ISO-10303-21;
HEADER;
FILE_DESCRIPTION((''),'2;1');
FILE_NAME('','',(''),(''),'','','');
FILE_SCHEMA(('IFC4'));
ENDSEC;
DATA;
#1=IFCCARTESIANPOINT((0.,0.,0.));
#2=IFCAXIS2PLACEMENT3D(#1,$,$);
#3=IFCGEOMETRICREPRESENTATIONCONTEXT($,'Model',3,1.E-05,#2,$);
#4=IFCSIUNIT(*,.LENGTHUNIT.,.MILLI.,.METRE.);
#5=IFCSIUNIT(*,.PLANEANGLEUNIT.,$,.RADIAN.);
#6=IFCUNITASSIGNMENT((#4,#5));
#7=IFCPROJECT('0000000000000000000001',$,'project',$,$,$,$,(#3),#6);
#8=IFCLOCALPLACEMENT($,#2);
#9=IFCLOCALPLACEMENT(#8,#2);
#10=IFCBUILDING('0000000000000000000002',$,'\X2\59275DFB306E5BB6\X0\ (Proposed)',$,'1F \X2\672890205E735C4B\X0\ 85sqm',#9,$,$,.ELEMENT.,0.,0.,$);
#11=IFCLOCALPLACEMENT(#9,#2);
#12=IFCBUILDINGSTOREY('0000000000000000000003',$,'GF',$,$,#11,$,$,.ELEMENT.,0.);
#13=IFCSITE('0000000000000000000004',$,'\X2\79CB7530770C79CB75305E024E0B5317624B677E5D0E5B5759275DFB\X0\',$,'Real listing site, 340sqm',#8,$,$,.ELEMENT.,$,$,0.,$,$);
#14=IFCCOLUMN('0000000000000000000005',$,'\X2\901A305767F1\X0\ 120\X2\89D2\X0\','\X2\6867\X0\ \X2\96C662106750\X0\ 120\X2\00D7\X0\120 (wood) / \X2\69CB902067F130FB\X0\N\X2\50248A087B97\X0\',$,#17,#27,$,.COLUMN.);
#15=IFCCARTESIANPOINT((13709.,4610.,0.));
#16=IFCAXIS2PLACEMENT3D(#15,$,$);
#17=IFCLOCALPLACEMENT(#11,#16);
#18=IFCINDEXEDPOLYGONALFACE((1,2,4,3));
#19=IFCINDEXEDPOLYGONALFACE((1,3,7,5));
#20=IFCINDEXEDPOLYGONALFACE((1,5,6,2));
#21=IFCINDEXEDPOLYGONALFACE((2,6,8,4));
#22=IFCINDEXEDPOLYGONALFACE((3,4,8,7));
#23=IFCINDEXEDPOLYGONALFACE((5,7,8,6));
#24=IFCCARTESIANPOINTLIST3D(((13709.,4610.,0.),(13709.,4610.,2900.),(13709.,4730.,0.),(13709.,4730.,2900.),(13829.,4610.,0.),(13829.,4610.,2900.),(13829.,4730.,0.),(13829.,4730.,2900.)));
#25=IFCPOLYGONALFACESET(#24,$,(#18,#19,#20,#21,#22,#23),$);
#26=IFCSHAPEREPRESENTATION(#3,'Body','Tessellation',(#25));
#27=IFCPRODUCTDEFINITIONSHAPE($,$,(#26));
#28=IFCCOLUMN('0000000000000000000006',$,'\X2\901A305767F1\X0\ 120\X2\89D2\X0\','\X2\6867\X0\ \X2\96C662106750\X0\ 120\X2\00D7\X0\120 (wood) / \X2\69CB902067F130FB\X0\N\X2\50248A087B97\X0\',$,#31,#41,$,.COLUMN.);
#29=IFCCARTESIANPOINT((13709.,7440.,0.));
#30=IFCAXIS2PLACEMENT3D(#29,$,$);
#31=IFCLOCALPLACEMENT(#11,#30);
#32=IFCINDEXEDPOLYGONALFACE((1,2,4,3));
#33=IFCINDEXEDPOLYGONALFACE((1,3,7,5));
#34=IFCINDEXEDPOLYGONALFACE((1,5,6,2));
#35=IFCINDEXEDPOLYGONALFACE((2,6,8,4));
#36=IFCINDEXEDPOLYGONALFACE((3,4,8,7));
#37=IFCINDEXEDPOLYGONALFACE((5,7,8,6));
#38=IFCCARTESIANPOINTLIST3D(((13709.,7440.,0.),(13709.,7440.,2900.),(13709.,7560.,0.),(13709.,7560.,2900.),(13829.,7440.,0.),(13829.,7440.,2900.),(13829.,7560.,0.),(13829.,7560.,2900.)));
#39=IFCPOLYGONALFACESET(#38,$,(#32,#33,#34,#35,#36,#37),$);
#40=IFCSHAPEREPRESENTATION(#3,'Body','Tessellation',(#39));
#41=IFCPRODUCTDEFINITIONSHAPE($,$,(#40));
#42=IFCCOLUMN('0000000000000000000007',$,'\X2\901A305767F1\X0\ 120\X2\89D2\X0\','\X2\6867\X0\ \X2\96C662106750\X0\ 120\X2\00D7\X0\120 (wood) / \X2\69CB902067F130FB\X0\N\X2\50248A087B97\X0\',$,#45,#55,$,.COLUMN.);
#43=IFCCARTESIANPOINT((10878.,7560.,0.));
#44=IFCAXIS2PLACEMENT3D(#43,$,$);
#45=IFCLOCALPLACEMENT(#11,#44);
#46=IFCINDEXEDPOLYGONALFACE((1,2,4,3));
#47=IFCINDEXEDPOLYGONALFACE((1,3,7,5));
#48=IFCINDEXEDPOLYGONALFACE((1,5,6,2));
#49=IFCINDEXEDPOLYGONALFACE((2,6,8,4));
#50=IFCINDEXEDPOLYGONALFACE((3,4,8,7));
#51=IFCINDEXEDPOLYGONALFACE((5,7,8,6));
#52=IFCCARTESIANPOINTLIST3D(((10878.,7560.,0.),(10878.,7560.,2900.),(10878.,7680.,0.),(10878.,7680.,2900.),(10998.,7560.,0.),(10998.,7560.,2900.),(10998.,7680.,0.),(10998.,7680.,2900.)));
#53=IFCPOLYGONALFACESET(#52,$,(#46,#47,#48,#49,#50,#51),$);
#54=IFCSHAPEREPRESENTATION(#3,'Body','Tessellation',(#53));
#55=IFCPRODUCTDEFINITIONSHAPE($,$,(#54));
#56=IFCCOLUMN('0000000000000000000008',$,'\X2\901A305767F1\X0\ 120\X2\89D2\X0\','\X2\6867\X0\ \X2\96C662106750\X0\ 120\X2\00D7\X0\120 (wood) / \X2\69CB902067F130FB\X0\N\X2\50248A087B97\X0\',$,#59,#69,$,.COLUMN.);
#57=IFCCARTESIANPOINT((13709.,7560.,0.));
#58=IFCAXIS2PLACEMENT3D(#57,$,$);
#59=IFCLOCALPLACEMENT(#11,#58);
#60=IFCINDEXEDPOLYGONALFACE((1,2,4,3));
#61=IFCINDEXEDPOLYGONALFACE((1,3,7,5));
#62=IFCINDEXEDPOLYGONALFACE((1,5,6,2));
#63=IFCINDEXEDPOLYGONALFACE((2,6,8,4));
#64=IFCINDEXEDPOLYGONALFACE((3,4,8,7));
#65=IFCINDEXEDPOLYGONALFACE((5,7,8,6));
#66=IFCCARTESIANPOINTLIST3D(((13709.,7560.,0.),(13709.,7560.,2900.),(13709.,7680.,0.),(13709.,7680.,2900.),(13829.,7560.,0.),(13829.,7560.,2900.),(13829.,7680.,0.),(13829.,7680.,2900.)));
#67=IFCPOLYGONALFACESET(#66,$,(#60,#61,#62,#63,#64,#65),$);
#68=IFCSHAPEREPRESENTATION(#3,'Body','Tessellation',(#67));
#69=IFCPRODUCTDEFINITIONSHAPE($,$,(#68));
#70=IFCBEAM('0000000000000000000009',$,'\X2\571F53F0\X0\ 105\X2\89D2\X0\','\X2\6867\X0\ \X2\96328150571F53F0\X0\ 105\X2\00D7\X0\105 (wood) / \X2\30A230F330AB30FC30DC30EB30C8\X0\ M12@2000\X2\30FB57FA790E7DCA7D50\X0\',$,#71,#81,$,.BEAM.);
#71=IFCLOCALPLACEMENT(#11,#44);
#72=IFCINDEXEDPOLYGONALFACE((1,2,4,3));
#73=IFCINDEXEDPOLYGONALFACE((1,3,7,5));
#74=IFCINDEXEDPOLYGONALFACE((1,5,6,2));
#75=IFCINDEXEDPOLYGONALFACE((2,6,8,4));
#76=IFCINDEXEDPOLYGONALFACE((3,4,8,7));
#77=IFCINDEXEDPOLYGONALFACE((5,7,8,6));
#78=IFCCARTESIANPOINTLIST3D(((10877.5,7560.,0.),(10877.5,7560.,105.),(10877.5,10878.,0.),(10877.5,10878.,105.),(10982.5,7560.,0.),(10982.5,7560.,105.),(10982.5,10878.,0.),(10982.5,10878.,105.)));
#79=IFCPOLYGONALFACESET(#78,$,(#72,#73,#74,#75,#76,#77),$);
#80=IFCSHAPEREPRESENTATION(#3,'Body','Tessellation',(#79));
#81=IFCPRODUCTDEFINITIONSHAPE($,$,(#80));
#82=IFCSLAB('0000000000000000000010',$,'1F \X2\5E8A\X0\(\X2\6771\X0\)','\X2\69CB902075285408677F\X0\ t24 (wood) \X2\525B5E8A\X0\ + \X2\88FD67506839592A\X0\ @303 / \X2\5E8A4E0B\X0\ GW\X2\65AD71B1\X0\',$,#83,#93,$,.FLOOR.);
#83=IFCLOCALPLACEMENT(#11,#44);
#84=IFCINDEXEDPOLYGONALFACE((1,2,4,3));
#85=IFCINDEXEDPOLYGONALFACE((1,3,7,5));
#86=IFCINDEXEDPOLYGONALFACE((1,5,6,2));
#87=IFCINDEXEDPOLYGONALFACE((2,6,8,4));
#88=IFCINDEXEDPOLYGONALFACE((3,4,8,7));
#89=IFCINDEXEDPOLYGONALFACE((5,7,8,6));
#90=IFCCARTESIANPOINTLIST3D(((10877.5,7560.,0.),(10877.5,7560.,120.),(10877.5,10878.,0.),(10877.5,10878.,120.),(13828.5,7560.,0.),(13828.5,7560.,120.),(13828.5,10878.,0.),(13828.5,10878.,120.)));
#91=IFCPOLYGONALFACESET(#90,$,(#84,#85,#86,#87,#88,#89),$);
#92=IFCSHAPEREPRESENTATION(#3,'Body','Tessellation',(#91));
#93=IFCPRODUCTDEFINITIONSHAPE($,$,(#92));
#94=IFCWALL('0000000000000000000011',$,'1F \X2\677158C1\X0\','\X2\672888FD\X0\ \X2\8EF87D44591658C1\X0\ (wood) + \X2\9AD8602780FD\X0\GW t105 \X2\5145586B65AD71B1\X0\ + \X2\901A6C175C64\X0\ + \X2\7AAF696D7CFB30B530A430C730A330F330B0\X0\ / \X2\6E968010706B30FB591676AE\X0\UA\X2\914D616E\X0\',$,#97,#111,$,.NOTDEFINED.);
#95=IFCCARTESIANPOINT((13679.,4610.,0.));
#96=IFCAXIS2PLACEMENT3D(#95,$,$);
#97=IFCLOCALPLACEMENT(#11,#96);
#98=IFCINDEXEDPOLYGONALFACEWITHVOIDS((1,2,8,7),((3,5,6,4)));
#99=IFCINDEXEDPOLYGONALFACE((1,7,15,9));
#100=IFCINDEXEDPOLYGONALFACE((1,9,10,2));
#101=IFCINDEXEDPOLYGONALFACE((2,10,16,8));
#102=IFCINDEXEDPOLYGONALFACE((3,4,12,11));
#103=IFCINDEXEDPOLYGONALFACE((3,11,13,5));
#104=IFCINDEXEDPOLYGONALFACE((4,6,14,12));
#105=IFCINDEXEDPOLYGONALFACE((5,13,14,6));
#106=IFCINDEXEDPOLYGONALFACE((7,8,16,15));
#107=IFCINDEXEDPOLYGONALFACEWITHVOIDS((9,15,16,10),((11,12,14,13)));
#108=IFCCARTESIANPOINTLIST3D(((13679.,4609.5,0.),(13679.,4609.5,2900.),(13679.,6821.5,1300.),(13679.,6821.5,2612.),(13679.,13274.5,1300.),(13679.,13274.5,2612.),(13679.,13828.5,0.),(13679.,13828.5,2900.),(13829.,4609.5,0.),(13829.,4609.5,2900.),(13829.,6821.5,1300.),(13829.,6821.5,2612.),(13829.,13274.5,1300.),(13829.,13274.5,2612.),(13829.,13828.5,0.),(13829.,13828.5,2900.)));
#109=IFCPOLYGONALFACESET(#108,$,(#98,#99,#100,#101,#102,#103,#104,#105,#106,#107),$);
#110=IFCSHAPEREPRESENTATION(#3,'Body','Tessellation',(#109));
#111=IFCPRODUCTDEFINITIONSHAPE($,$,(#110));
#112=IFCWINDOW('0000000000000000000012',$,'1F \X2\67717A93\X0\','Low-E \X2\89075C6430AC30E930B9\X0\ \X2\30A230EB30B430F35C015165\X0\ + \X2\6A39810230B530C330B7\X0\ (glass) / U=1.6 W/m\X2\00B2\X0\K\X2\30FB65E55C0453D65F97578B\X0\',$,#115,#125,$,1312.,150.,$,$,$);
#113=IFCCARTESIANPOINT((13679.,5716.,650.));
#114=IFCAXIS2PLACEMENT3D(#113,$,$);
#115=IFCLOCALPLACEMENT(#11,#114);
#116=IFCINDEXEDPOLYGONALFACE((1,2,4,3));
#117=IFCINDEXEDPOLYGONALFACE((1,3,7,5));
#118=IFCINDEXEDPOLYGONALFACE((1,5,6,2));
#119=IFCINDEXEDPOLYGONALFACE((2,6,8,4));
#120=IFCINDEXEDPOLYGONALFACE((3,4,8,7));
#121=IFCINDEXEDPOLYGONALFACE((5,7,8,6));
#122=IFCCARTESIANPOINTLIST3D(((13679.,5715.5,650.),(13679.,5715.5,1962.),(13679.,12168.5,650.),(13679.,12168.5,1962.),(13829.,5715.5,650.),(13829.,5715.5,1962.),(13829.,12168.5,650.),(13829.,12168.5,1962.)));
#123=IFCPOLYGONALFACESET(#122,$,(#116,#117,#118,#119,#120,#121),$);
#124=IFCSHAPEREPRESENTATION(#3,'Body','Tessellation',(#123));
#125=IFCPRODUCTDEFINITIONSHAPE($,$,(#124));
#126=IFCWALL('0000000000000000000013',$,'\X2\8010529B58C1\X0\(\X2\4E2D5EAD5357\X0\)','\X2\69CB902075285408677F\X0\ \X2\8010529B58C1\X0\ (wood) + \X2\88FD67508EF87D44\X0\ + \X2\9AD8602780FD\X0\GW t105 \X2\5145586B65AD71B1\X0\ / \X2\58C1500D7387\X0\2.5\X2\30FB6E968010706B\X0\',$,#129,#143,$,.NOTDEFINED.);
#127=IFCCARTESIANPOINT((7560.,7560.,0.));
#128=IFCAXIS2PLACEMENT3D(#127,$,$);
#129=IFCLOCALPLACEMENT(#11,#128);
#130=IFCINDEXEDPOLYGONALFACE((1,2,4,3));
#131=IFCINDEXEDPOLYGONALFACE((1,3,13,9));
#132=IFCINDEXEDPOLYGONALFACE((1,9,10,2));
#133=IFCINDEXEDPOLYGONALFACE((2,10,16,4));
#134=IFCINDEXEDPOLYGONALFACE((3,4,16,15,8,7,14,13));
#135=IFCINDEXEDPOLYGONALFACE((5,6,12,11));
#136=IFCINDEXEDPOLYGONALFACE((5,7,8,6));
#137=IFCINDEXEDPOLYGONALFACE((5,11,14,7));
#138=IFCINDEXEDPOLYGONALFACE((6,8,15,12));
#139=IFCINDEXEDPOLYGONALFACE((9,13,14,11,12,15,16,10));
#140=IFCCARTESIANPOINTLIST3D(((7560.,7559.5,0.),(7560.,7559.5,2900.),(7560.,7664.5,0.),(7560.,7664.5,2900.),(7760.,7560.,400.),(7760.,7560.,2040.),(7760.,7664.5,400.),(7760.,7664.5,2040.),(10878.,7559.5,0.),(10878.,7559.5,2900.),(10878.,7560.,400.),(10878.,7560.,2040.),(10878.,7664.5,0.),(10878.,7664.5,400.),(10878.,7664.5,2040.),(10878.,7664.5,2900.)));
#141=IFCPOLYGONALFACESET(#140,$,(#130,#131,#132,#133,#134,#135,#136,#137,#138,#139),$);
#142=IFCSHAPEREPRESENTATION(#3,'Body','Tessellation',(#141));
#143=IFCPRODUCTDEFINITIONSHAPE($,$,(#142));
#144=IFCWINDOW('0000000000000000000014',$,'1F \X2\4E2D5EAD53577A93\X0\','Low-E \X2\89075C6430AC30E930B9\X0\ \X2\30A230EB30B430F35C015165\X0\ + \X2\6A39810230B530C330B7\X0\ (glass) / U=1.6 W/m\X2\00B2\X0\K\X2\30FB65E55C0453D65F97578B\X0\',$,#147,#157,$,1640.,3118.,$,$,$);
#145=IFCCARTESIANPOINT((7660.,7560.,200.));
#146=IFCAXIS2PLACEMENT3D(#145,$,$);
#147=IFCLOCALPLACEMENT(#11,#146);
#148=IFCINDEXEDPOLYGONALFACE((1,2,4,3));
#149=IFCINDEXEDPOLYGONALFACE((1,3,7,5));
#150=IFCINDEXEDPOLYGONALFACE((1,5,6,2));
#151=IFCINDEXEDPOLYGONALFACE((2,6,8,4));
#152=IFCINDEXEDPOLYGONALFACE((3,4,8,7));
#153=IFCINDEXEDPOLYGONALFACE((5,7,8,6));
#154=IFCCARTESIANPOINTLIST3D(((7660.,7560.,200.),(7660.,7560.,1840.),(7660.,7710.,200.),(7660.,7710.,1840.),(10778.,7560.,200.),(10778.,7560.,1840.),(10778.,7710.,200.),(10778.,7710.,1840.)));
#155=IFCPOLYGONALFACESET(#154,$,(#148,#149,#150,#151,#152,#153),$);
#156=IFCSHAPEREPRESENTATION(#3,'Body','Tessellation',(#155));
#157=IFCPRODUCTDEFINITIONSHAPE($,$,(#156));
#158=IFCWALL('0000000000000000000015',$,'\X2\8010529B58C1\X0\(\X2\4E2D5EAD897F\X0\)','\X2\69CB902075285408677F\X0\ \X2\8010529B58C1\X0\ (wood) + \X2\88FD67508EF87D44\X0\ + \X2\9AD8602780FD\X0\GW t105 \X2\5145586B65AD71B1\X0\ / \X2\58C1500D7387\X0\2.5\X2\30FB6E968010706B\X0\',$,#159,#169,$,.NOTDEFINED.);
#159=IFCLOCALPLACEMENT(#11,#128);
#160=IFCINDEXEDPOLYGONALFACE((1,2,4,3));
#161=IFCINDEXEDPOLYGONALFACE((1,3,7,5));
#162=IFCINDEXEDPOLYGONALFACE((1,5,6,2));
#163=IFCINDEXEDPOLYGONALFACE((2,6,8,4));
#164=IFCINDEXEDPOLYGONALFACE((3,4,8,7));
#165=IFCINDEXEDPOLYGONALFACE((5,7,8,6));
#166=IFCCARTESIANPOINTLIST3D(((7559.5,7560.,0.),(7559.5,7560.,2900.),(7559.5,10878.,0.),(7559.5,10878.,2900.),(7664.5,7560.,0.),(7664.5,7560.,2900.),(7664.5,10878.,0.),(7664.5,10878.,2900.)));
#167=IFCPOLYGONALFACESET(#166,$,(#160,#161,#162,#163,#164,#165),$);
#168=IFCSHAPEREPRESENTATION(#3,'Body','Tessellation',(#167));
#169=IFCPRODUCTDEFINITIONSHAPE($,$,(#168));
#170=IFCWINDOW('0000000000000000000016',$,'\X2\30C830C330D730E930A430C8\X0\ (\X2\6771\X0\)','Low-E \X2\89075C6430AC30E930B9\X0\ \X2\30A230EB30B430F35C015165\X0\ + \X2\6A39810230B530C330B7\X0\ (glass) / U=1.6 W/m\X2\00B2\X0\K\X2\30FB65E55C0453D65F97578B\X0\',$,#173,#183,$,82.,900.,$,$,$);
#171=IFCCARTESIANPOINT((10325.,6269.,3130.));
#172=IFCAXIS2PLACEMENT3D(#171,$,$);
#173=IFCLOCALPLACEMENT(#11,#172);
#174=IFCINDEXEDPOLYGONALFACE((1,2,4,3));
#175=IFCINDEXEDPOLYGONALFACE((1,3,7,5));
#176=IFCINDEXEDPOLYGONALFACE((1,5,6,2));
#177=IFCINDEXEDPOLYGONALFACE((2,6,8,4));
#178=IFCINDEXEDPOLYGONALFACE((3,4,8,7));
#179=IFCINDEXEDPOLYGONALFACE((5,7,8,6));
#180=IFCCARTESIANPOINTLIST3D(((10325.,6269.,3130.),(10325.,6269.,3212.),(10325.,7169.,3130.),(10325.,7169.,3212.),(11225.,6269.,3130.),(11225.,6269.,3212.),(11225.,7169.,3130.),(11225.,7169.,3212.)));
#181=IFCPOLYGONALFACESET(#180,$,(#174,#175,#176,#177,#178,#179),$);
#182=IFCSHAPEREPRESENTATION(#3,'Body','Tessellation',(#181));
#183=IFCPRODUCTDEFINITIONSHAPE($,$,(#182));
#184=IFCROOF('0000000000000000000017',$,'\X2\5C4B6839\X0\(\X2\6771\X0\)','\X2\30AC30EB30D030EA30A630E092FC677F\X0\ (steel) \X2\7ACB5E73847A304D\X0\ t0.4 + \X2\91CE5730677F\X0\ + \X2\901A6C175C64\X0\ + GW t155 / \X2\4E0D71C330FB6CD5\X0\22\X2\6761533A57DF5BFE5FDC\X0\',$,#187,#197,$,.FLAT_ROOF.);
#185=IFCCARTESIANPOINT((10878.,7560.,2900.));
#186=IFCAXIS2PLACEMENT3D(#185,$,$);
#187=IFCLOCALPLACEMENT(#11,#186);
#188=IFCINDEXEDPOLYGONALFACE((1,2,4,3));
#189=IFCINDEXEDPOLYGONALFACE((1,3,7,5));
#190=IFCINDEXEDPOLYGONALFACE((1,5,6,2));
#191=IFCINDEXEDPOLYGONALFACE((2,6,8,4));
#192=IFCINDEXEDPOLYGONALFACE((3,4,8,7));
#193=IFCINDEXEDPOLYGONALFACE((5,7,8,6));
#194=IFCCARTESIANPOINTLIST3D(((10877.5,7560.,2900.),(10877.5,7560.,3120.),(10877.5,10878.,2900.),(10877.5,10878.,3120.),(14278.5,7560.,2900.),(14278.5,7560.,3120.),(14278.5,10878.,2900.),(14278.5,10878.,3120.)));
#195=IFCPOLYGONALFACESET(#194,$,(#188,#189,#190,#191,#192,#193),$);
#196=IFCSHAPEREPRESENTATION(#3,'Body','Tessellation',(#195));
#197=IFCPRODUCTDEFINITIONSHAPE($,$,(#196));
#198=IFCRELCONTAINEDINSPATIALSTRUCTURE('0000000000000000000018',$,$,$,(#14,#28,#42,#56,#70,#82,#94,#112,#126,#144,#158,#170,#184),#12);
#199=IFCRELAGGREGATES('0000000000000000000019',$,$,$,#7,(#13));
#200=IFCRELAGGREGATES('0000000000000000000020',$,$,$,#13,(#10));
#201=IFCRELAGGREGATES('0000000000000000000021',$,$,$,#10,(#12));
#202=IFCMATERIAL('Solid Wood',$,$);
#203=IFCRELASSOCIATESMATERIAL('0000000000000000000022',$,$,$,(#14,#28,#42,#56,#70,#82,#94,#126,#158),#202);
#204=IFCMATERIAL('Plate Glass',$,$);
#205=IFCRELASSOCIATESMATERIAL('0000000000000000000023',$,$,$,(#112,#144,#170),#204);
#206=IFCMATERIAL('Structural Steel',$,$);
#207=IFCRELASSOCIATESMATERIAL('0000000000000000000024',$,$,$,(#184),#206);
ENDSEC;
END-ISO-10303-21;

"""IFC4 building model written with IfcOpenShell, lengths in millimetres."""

from ifc_helpers import new_model, si_unit, frame, frame_2d, origin, place, context, project, spatial, rectangle, extrude, material, element, fill, save


model = new_model("IFC4")

# Units and contexts
model_context = context("Model", 3, precision=1e-05, world=origin())
ifc_project = project(units=[si_unit("LENGTHUNIT", "METRE", prefix="MILLI"), si_unit("PLANEANGLEUNIT", "RADIAN")], contexts=[model_context])

# Site, building, storey
site_placement = place(None, origin())
site = spatial("IfcSite", under=ifc_project, at=site_placement, Name="秋田県秋田市下北手松崎字大巻", ObjectType="Real listing site, 340sqm", CompositionType="ELEMENT", RefElevation=0.0)
building_placement = place(site_placement, origin())
building = spatial("IfcBuilding", under=site, at=building_placement, Name="大巻の家 (Proposed)", ObjectType="1F 木造平屋 85sqm", CompositionType="ELEMENT", ElevationOfRefHeight=0.0, ElevationOfTerrain=0.0)
storey_placement = place(building_placement, origin())
storey = spatial("IfcBuildingStorey", under=building, at=storey_placement, Name="GF", CompositionType="ELEMENT", Elevation=0.0)

# Columns
ifc_material_1 = material(Name="Solid Wood")
column_1_placement = place(storey_placement, frame((13709.0, 4610.0, 0.0)))
element("IfcColumn", 1, at=column_1_placement, inside=storey, material=ifc_material_1, Name="通し柱 120角", Description="桧 集成材 120×120 (wood) / 構造柱・N値計算", PredefinedType="COLUMN", context=model_context, shape_type="SweptSolid", body=[
    extrude(rectangle(XDim=120.0, YDim=120.0, at=frame_2d((60.0, 60.0))), frame((13709.0, 4610.0, 0.0)), (0.0, 0.0, 1.0), 2900.0),
])
column_2_placement = place(storey_placement, frame((13709.0, 7440.0, 0.0)))
element("IfcColumn", 2, at=column_2_placement, inside=storey, material=ifc_material_1, Name="通し柱 120角", Description="桧 集成材 120×120 (wood) / 構造柱・N値計算", PredefinedType="COLUMN", context=model_context, shape_type="SweptSolid", body=[
    extrude(rectangle(XDim=120.0, YDim=120.0, at=frame_2d((60.0, 60.0))), frame((13709.0, 7440.0, 0.0)), (0.0, 0.0, 1.0), 2900.0),
])
column_3_placement = place(storey_placement, frame((10878.0, 7560.0, 0.0)))
element("IfcColumn", 3, at=column_3_placement, inside=storey, material=ifc_material_1, Name="通し柱 120角", Description="桧 集成材 120×120 (wood) / 構造柱・N値計算", PredefinedType="COLUMN", context=model_context, shape_type="SweptSolid", body=[
    extrude(rectangle(XDim=120.0, YDim=120.0, at=frame_2d((60.0, 60.0))), frame((10878.0, 7560.0, 0.0)), (0.0, 0.0, 1.0), 2900.0),
])
column_4_placement = place(storey_placement, frame((13709.0, 7560.0, 0.0)))
element("IfcColumn", 4, at=column_4_placement, inside=storey, material=ifc_material_1, Name="通し柱 120角", Description="桧 集成材 120×120 (wood) / 構造柱・N値計算", PredefinedType="COLUMN", context=model_context, shape_type="SweptSolid", body=[
    extrude(rectangle(XDim=120.0, YDim=120.0, at=frame_2d((60.0, 60.0))), frame((13709.0, 7560.0, 0.0)), (0.0, 0.0, 1.0), 2900.0),
])

# Beam
beam_1_placement = place(storey_placement, frame((10878.0, 7560.0, 0.0)))
element("IfcBeam", 5, at=beam_1_placement, inside=storey, material=ifc_material_1, Name="土台 105角", Description="桧 防腐土台 105×105 (wood) / アンカーボルト M12@2000・基礎緊結", PredefinedType="BEAM", context=model_context, shape_type="SweptSolid", body=[
    extrude(rectangle(XDim=105.0, YDim=3318.0, at=frame_2d((52.0, 1659.0))), frame((10878.0, 7560.0, 0.0)), (0.0, 0.0, 1.0), 105.0),
])

# Slab
slab_placement = place(storey_placement, frame((10878.0, 7560.0, 0.0)))
element("IfcSlab", 6, at=slab_placement, inside=storey, material=ifc_material_1, Name="1F 床(東)", Description="構造用合板 t24 (wood) 剛床 + 製材根太 @303 / 床下 GW断熱", PredefinedType="FLOOR", context=model_context, shape_type="SweptSolid", body=[
    extrude(rectangle(XDim=2951.0, YDim=3318.0, at=frame_2d((1475.0, 1659.0))), frame((10878.0, 7560.0, 0.0)), (0.0, 0.0, 1.0), 120.0),
])

# Walls, openings, windows
wall_1_placement = place(storey_placement, frame((13679.0, 4610.0, 0.0)))
wall_1 = element("IfcWall", 7, at=wall_1_placement, inside=storey, material=ifc_material_1, Name="1F 東壁", Description="木製 軸組外壁 (wood) + 高性能GW t105 充填断熱 + 通気層 + 窯業系サイディング / 準耐火・外皮UA配慮", PredefinedType="NOTDEFINED", context=model_context, shape_type="SweptSolid", body=[
    extrude(rectangle(XDim=150.0, YDim=9219.0, at=frame_2d((75.0, 4609.0))), frame((13679.0, 4610.0, 0.0)), (0.0, 0.0, 1.0), 2900.0),
])
opening_1_placement = place(storey_placement, frame((13679.0, 5716.0, 650.0)))
opening_1 = element("IfcOpeningElement", 8, at=opening_1_placement, cuts=wall_1, PredefinedType="NOTDEFINED", context=model_context, shape_type="SweptSolid", body=[
    extrude(rectangle(XDim=150.0, YDim=6453.0, at=frame_2d((75.0, 3226.0))), frame((13679.0, 5716.0, 650.0)), (0.0, 0.0, 1.0), 1312.0),
])
ifc_material_2 = material(Name="Plate Glass")
window_1_placement = place(storey_placement, frame((13679.0, 5716.0, 650.0)))
window_1 = element("IfcWindow", 9, at=window_1_placement, inside=storey, material=ifc_material_2, Name="1F 東窓", Description="Low-E 複層ガラス アルゴン封入 + 樹脂サッシ (glass) / U=1.6 W/m²K・日射取得型", OverallHeight=1312.0, OverallWidth=150.0, context=model_context, shape_type="SweptSolid", body=[
    extrude(rectangle(XDim=150.0, YDim=6453.0, at=frame_2d((75.0, 3226.0))), frame((13679.0, 5716.0, 650.0)), (0.0, 0.0, 1.0), 1312.0),
])
fill(opening_1, window_1)
wall_2_placement = place(storey_placement, frame((7560.0, 7560.0, 0.0)))
wall_2 = element("IfcWall", 10, at=wall_2_placement, inside=storey, material=ifc_material_1, Name="耐力壁(中庭南)", Description="構造用合板 耐力壁 (wood) + 製材軸組 + 高性能GW t105 充填断熱 / 壁倍率2.5・準耐火", PredefinedType="NOTDEFINED", context=model_context, shape_type="SweptSolid", body=[
    extrude(rectangle(XDim=3318.0, YDim=105.0, at=frame_2d((1659.0, 52.0))), frame((7560.0, 7560.0, 0.0)), (0.0, 0.0, 1.0), 2900.0),
])
opening_2_placement = place(storey_placement, frame((7660.0, 7560.0, 200.0)))
opening_2 = element("IfcOpeningElement", 11, at=opening_2_placement, cuts=wall_2, PredefinedType="NOTDEFINED", context=model_context, shape_type="SweptSolid", body=[
    extrude(rectangle(XDim=3118.0, YDim=150.0, at=frame_2d((1559.0, 75.0))), frame((7660.0, 7560.0, 200.0)), (0.0, 0.0, 1.0), 1640.0),
])
window_2_placement = place(storey_placement, frame((7660.0, 7560.0, 200.0)))
window_2 = element("IfcWindow", 12, at=window_2_placement, inside=storey, material=ifc_material_2, Name="1F 中庭南窓", Description="Low-E 複層ガラス アルゴン封入 + 樹脂サッシ (glass) / U=1.6 W/m²K・日射取得型", OverallHeight=1640.0, OverallWidth=3118.0, context=model_context, shape_type="SweptSolid", body=[
    extrude(rectangle(XDim=3118.0, YDim=150.0, at=frame_2d((1559.0, 75.0))), frame((7660.0, 7560.0, 200.0)), (0.0, 0.0, 1.0), 1640.0),
])
fill(opening_2, window_2)

# Wall
wall_3_placement = place(storey_placement, frame((7560.0, 7560.0, 0.0)))
element("IfcWall", 13, at=wall_3_placement, inside=storey, material=ifc_material_1, Name="耐力壁(中庭西)", Description="構造用合板 耐力壁 (wood) + 製材軸組 + 高性能GW t105 充填断熱 / 壁倍率2.5・準耐火", PredefinedType="NOTDEFINED", context=model_context, shape_type="SweptSolid", body=[
    extrude(rectangle(XDim=105.0, YDim=3318.0, at=frame_2d((52.0, 1659.0))), frame((7560.0, 7560.0, 0.0)), (0.0, 0.0, 1.0), 2900.0),
])

# Window
window_3_placement = place(storey_placement, frame((10325.0, 6269.0, 3130.0)))
element("IfcWindow", 14, at=window_3_placement, inside=storey, material=ifc_material_2, Name="トップライト (東)", Description="Low-E 複層ガラス アルゴン封入 + 樹脂サッシ (glass) / U=1.6 W/m²K・日射取得型", OverallHeight=82.0, OverallWidth=900.0, context=model_context, shape_type="SweptSolid", body=[
    extrude(rectangle(XDim=900.0, YDim=900.0, at=frame_2d((450.0, 450.0))), frame((10325.0, 6269.0, 3130.0)), (0.0, 0.0, 1.0), 82.0),
])

# Roof
ifc_material_3 = material(Name="Structural Steel")
roof_placement = place(storey_placement, frame((10878.0, 7560.0, 2900.0)))
element("IfcRoof", 15, at=roof_placement, inside=storey, material=ifc_material_3, Name="屋根(東)", Description="ガルバリウム鋼板 (steel) 立平葺き t0.4 + 野地板 + 通気層 + GW t155 / 不燃・法22条区域対応", PredefinedType="FLAT_ROOF", context=model_context, shape_type="SweptSolid", body=[
    extrude(rectangle(XDim=3401.0, YDim=3318.0, at=frame_2d((1700.0, 1659.0))), frame((10878.0, 7560.0, 2900.0)), (0.0, 0.0, 1.0), 220.0),
])

save(model, "model.ifc")
